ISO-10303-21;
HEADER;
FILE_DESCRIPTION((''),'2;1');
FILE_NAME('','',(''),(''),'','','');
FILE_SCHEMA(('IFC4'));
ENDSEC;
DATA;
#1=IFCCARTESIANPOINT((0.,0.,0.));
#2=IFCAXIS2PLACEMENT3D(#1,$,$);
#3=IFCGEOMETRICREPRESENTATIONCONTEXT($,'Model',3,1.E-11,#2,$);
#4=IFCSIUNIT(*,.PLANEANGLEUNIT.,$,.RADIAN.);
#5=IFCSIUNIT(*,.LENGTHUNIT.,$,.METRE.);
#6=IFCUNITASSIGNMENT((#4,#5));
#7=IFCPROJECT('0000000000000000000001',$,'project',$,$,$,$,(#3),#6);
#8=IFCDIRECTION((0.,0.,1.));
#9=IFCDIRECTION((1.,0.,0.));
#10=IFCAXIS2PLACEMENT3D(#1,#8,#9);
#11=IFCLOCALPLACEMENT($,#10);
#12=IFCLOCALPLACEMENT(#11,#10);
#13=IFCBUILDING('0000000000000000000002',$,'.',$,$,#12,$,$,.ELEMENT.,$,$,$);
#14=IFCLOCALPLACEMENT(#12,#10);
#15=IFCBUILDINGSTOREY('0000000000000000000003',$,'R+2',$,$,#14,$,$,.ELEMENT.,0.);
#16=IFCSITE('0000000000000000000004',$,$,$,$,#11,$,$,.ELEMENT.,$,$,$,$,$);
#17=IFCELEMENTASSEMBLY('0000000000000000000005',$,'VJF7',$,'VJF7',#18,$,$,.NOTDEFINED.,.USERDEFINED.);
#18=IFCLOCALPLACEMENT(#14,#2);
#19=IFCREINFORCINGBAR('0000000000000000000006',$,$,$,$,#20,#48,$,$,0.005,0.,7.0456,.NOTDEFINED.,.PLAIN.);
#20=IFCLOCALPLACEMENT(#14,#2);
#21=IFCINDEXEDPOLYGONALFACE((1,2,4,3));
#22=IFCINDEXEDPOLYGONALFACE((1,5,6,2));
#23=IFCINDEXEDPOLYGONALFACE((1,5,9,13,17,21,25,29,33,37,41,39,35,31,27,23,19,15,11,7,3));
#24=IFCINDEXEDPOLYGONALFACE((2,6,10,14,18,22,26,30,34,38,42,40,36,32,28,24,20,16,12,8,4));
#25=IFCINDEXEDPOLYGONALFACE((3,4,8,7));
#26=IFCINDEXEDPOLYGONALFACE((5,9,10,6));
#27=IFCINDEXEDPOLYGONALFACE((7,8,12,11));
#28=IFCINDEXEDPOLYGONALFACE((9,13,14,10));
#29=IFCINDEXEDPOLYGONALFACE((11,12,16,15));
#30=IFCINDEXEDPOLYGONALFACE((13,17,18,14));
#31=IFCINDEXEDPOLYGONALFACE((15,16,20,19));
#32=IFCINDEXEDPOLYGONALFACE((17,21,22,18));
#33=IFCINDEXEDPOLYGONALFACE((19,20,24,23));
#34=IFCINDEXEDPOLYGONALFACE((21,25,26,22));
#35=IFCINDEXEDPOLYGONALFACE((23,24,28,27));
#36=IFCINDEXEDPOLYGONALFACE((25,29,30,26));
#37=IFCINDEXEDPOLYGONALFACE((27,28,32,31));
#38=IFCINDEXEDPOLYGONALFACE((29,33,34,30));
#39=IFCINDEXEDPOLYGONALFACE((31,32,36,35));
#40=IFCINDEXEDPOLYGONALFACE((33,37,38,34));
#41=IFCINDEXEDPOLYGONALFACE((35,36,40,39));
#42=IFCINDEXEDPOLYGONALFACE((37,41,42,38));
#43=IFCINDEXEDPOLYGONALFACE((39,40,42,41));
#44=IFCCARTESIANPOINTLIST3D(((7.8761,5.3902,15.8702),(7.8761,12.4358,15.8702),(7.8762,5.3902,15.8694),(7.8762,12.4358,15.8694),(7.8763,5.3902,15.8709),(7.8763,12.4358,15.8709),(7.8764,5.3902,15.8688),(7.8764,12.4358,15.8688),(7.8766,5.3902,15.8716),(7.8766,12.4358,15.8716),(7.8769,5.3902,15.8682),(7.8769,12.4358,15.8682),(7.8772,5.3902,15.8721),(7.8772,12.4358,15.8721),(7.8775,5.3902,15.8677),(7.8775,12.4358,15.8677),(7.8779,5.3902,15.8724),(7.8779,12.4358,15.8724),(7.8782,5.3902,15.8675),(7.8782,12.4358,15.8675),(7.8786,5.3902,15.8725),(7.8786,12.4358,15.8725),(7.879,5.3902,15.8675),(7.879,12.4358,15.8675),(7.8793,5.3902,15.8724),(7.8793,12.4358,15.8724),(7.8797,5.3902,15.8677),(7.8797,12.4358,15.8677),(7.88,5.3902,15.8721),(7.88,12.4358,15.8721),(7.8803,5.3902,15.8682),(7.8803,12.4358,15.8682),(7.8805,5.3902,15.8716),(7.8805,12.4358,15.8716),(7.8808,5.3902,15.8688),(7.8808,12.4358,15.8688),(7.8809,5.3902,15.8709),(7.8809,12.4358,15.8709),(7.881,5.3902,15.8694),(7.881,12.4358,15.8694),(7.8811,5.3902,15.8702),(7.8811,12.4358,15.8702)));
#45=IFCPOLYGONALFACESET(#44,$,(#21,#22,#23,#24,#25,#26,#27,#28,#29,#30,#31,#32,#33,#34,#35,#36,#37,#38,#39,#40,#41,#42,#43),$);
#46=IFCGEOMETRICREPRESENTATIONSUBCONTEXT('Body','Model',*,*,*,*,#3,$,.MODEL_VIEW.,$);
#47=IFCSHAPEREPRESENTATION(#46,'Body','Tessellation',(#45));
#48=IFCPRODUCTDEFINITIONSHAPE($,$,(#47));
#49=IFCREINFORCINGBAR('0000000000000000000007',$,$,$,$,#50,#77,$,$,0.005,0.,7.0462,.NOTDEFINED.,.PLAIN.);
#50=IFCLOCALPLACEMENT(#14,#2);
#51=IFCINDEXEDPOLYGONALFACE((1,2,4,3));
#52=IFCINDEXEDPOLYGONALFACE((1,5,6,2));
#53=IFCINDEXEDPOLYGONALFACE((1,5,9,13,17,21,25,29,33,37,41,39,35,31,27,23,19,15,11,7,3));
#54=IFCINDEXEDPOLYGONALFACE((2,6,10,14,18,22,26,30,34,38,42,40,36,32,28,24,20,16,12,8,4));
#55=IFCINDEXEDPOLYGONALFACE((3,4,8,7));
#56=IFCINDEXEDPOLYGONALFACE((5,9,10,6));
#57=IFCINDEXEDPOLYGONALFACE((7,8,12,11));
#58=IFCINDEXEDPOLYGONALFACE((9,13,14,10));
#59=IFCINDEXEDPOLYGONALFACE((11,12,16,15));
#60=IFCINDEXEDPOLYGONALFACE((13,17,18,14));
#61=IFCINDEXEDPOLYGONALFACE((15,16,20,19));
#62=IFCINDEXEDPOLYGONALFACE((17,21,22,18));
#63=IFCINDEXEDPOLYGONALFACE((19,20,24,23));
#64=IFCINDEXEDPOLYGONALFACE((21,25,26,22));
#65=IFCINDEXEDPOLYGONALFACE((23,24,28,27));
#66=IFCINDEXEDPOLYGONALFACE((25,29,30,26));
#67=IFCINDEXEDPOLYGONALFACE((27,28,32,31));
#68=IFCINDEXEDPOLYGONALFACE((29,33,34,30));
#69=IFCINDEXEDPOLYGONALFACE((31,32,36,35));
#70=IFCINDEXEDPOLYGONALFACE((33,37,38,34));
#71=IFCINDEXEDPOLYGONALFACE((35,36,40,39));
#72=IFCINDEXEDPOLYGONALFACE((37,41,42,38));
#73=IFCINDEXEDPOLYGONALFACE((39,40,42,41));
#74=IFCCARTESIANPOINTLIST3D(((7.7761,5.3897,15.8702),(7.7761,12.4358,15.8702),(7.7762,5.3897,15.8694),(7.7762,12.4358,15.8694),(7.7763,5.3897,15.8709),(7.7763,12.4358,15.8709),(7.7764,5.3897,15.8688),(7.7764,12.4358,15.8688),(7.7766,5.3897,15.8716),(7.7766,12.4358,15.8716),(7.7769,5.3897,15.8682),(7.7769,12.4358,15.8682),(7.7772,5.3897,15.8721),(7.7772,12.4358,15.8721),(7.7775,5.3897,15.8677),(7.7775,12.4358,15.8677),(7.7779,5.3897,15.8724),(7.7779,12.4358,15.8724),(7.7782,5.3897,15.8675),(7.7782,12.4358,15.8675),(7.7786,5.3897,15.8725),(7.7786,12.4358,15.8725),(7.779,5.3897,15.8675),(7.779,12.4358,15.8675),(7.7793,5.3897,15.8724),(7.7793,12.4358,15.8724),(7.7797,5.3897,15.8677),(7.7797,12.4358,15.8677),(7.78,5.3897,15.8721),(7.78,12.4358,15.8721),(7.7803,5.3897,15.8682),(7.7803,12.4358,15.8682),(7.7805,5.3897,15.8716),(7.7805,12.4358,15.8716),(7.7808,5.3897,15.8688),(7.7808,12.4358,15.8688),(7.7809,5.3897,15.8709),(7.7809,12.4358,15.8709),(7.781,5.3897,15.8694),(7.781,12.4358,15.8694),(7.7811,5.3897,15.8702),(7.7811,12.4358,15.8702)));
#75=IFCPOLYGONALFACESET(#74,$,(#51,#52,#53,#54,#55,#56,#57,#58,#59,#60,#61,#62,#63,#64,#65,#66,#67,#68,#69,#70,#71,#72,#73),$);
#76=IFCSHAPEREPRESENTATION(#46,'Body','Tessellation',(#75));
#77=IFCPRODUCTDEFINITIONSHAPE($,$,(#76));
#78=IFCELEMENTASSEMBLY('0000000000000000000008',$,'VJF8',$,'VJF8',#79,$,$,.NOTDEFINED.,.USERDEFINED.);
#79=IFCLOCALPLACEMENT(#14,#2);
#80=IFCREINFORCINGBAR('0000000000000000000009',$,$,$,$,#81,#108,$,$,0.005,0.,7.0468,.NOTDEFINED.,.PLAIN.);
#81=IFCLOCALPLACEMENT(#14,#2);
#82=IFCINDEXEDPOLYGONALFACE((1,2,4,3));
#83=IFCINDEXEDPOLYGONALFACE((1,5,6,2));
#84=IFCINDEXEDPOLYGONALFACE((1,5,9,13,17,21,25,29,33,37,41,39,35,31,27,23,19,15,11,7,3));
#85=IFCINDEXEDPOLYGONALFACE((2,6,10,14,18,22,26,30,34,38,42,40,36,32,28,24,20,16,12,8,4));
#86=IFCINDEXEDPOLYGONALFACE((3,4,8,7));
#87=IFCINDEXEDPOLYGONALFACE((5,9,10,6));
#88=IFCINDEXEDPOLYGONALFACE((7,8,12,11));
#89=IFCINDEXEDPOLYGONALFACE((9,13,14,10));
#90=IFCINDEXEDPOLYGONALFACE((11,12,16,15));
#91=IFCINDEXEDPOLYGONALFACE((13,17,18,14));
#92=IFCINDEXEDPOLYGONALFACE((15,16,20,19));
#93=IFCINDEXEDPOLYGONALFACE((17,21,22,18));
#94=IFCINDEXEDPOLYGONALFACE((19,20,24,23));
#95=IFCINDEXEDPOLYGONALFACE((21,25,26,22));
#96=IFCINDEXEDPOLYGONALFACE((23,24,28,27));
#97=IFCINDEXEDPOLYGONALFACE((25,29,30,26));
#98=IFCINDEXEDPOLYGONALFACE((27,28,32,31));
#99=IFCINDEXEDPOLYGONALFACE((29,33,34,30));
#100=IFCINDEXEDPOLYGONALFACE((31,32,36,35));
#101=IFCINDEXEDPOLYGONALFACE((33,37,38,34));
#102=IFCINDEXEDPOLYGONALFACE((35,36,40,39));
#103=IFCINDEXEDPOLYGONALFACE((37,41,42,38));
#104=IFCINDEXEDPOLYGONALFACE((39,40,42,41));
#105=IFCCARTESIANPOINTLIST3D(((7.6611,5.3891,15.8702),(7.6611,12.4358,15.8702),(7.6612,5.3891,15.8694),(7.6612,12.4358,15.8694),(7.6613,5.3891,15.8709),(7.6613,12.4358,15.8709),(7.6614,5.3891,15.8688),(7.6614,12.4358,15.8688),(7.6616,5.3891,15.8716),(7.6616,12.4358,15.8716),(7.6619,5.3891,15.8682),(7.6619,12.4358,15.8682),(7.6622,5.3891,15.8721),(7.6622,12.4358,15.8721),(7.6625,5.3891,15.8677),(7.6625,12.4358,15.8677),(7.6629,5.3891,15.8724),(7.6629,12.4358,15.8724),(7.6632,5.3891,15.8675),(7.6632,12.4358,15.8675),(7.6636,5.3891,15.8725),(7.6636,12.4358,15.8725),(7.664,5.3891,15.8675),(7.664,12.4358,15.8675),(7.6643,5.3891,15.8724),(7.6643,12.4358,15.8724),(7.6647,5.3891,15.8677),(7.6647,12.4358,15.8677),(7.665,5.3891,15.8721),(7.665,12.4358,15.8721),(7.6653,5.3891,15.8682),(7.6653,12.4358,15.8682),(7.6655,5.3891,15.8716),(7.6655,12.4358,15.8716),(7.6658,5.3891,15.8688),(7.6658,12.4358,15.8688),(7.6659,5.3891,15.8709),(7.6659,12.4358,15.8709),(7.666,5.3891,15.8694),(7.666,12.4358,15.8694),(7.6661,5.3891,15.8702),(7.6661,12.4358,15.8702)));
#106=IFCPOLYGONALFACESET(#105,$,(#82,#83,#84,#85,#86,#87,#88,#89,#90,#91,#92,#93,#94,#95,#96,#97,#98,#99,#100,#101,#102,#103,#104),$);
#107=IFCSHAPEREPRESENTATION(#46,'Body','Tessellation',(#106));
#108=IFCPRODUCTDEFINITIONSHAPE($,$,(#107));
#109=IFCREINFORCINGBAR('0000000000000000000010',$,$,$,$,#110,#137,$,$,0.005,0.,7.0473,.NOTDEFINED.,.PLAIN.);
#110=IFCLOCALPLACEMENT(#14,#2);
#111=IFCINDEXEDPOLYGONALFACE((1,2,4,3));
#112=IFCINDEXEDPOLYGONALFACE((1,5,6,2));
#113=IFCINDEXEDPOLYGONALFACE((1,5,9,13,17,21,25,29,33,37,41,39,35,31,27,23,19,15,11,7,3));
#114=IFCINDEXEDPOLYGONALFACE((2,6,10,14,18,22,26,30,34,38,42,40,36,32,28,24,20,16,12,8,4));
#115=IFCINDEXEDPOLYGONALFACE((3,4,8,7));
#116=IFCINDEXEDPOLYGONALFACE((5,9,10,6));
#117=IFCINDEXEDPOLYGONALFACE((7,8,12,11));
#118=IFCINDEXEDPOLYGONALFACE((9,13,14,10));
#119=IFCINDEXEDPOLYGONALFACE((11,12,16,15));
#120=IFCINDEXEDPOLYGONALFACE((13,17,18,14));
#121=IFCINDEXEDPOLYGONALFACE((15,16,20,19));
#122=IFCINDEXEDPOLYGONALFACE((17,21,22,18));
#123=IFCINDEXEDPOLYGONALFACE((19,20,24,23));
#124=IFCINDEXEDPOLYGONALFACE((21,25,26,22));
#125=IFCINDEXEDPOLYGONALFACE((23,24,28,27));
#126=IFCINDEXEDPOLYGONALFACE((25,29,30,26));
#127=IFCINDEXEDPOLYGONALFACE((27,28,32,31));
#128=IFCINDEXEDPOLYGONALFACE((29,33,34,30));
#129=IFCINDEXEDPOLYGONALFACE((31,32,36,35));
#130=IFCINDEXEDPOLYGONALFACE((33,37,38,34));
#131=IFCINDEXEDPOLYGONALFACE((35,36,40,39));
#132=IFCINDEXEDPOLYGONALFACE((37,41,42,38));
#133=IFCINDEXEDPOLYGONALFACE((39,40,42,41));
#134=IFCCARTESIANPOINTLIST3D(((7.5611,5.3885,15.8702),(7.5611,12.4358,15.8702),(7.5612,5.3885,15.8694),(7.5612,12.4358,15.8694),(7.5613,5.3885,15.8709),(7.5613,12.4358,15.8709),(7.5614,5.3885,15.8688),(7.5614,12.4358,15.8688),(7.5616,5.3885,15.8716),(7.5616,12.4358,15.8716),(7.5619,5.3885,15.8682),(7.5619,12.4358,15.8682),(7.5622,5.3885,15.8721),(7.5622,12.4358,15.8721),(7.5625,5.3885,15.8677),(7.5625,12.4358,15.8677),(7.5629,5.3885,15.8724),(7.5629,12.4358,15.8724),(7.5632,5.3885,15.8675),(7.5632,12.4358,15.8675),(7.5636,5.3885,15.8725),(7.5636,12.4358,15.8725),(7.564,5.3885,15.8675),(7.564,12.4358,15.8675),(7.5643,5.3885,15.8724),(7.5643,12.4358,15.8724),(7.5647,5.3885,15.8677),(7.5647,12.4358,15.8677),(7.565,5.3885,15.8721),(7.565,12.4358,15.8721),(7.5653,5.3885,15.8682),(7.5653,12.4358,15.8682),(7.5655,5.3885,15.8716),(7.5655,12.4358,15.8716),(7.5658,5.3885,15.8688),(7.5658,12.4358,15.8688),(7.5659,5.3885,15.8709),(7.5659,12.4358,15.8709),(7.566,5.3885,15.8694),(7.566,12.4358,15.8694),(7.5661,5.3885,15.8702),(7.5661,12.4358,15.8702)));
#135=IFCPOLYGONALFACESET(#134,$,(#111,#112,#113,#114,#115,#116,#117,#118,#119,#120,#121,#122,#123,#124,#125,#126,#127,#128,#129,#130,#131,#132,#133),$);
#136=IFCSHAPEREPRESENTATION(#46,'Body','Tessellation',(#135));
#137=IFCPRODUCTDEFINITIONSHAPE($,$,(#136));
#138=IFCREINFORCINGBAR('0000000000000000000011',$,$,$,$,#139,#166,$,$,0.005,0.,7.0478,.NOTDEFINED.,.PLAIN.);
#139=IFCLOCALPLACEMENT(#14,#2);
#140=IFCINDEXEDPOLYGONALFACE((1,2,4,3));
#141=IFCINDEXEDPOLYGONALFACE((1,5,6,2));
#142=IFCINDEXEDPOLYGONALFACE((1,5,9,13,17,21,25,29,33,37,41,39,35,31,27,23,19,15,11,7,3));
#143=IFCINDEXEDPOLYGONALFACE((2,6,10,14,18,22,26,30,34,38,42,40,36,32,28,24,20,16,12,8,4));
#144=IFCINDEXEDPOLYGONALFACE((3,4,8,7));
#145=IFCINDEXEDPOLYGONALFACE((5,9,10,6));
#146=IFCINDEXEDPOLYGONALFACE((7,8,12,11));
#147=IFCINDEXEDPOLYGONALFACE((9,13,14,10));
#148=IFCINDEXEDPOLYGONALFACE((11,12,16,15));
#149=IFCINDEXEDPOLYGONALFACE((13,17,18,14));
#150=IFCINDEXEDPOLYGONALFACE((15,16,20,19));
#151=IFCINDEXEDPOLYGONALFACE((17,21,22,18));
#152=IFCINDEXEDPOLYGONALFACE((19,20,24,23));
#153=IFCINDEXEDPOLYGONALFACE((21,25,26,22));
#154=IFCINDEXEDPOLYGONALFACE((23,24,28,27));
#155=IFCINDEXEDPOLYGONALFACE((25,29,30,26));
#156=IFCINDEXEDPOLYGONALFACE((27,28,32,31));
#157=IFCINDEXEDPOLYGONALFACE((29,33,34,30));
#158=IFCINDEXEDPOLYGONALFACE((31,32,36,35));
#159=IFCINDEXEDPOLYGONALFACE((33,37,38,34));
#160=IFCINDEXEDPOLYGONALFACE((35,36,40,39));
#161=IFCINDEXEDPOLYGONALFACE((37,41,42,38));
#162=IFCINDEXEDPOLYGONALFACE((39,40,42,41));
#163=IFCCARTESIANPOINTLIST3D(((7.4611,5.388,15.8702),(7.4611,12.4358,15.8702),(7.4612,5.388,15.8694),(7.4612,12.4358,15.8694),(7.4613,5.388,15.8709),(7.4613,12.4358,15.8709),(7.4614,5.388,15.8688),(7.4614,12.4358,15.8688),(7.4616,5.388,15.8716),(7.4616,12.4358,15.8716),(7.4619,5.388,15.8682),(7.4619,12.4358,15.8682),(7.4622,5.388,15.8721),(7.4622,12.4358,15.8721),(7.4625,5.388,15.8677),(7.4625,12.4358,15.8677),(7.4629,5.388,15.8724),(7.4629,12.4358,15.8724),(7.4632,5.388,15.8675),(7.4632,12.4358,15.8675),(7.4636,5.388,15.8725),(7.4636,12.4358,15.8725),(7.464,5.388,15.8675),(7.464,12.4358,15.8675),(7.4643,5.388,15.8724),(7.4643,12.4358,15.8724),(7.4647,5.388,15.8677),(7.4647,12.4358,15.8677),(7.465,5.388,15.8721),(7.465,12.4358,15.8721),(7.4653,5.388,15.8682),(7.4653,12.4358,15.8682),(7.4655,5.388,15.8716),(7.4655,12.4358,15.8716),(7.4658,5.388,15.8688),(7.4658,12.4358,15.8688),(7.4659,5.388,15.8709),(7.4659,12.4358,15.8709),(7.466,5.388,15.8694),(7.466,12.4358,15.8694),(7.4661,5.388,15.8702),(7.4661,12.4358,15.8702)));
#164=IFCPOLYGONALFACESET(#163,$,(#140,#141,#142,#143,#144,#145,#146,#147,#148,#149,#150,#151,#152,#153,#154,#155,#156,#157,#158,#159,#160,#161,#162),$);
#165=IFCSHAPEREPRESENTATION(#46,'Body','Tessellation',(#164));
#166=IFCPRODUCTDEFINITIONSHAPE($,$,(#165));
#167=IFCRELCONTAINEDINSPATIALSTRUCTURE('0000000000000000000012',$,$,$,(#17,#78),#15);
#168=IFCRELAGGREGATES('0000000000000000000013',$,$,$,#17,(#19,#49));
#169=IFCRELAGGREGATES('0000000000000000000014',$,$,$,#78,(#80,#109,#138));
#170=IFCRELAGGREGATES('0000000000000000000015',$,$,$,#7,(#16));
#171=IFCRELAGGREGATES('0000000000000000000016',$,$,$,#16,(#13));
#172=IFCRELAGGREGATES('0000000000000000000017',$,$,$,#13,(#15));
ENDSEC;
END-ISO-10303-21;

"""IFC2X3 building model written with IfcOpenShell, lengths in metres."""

from ifc_helpers import new_model, entity, si_unit, origin, origin_with_axes, place, context, subcontext, project, spatial, shape, element, aggregate, save


model = new_model("IFC2X3")

# Units and contexts
model_context = context("Model", 3, precision=1e-11, world=origin())
body_context = subcontext(model_context, "Body", "Model", "MODEL_VIEW")
ifc_project = project(units=[si_unit("PLANEANGLEUNIT", "RADIAN"), si_unit("LENGTHUNIT", "METRE")], contexts=[model_context])

# Site, building, storey
site_placement = place(None, origin_with_axes())
site = spatial("IfcSite", under=ifc_project, at=site_placement, CompositionType="ELEMENT")
building_placement = place(site_placement, origin_with_axes())
building = spatial("IfcBuilding", under=site, at=building_placement, Name=".", CompositionType="ELEMENT")
storey_placement = place(building_placement, origin_with_axes())
storey = spatial("IfcBuildingStorey", under=building, at=storey_placement, Name="R+2", CompositionType="ELEMENT", Elevation=0.0)

# Element assemblies, reinforcing bars
assembly_1_placement = place(storey_placement, origin_with_axes())
assembly_1 = element("IfcElementAssembly", 1, at=assembly_1_placement, inside=storey, Name="VJF7", ObjectType="VJF7", AssemblyPlace="NOTDEFINED", PredefinedType="USERDEFINED")
reinforcing_bar_1_placement = place(assembly_1_placement, origin_with_axes())
reinforcing_bar_1 = element("IfcReinforcingBar", 2, at=reinforcing_bar_1_placement, BarLength=7.0456, BarRole="NOTDEFINED", BarSurface="PLAIN", CrossSectionArea=0.0, NominalDiameter=0.005, shapes=[
    shape(body_context, "Body", "AdvancedSweptSolid", [entity("IfcSweptDiskSolid", entity("IfcPolyline", [entity("IfcCartesianPoint", [7.8786, 5.3902, 15.87]), entity("IfcCartesianPoint", [7.8786, 12.4358, 15.87])]), 0.0025, None, 0.0, 7.0456)]),
    shape(body_context, "Body", "AdvancedSweptSolid", [entity("IfcSweptDiskSolid", entity("IfcPolyline", [entity("IfcCartesianPoint", [7.8786, 5.3902, 15.87]), entity("IfcCartesianPoint", [7.8786, 12.4358, 15.87])]), 0.0025, None, 0.0, 7.0456)]),
])
reinforcing_bar_2_placement = place(assembly_1_placement, origin_with_axes())
reinforcing_bar_2 = element("IfcReinforcingBar", 3, at=reinforcing_bar_2_placement, BarLength=7.0462, BarRole="NOTDEFINED", BarSurface="PLAIN", CrossSectionArea=0.0, NominalDiameter=0.005, shapes=[
    shape(body_context, "Body", "AdvancedSweptSolid", [entity("IfcSweptDiskSolid", entity("IfcPolyline", [entity("IfcCartesianPoint", [7.7786, 5.3897, 15.87]), entity("IfcCartesianPoint", [7.7786, 12.4358, 15.87])]), 0.0025, None, 0.0, 7.0462)]),
    shape(body_context, "Body", "AdvancedSweptSolid", [entity("IfcSweptDiskSolid", entity("IfcPolyline", [entity("IfcCartesianPoint", [7.7786, 5.3897, 15.87]), entity("IfcCartesianPoint", [7.7786, 12.4358, 15.87])]), 0.0025, None, 0.0, 7.0462)]),
])
aggregate(assembly_1, [reinforcing_bar_1, reinforcing_bar_2])
assembly_2_placement = place(storey_placement, origin_with_axes())
assembly_2 = element("IfcElementAssembly", 4, at=assembly_2_placement, inside=storey, Name="VJF8", ObjectType="VJF8", AssemblyPlace="NOTDEFINED", PredefinedType="USERDEFINED")
reinforcing_bar_3_placement = place(assembly_2_placement, origin_with_axes())
reinforcing_bar_3 = element("IfcReinforcingBar", 5, at=reinforcing_bar_3_placement, BarLength=7.0468, BarRole="NOTDEFINED", BarSurface="PLAIN", CrossSectionArea=0.0, NominalDiameter=0.005, shapes=[
    shape(body_context, "Body", "AdvancedSweptSolid", [entity("IfcSweptDiskSolid", entity("IfcPolyline", [entity("IfcCartesianPoint", [7.6636, 5.3891, 15.87]), entity("IfcCartesianPoint", [7.6636, 12.4358, 15.87])]), 0.0025, None, 0.0, 7.0468)]),
    shape(body_context, "Body", "AdvancedSweptSolid", [entity("IfcSweptDiskSolid", entity("IfcPolyline", [entity("IfcCartesianPoint", [7.6636, 5.3891, 15.87]), entity("IfcCartesianPoint", [7.6636, 12.4358, 15.87])]), 0.0025, None, 0.0, 7.0468)]),
])
reinforcing_bar_4_placement = place(assembly_2_placement, origin_with_axes())
reinforcing_bar_4 = element("IfcReinforcingBar", 6, at=reinforcing_bar_4_placement, BarLength=7.0473, BarRole="NOTDEFINED", BarSurface="PLAIN", CrossSectionArea=0.0, NominalDiameter=0.005, shapes=[
    shape(body_context, "Body", "AdvancedSweptSolid", [entity("IfcSweptDiskSolid", entity("IfcPolyline", [entity("IfcCartesianPoint", [7.5636, 5.3885, 15.87]), entity("IfcCartesianPoint", [7.5636, 12.4358, 15.87])]), 0.0025, None, 0.0, 7.0473)]),
    shape(body_context, "Body", "AdvancedSweptSolid", [entity("IfcSweptDiskSolid", entity("IfcPolyline", [entity("IfcCartesianPoint", [7.5636, 5.3885, 15.87]), entity("IfcCartesianPoint", [7.5636, 12.4358, 15.87])]), 0.0025, None, 0.0, 7.0473)]),
])
reinforcing_bar_5_placement = place(assembly_2_placement, origin_with_axes())
reinforcing_bar_5 = element("IfcReinforcingBar", 7, at=reinforcing_bar_5_placement, BarLength=7.0478, BarRole="NOTDEFINED", BarSurface="PLAIN", CrossSectionArea=0.0, NominalDiameter=0.005, shapes=[
    shape(body_context, "Body", "AdvancedSweptSolid", [entity("IfcSweptDiskSolid", entity("IfcPolyline", [entity("IfcCartesianPoint", [7.4636, 5.388, 15.87]), entity("IfcCartesianPoint", [7.4636, 12.4358, 15.87])]), 0.0025, None, 0.0, 7.0478)]),
    shape(body_context, "Body", "AdvancedSweptSolid", [entity("IfcSweptDiskSolid", entity("IfcPolyline", [entity("IfcCartesianPoint", [7.4636, 5.388, 15.87]), entity("IfcCartesianPoint", [7.4636, 12.4358, 15.87])]), 0.0025, None, 0.0, 7.0478)]),
])
aggregate(assembly_2, [reinforcing_bar_3, reinforcing_bar_4, reinforcing_bar_5])

save(model, "model.ifc")
